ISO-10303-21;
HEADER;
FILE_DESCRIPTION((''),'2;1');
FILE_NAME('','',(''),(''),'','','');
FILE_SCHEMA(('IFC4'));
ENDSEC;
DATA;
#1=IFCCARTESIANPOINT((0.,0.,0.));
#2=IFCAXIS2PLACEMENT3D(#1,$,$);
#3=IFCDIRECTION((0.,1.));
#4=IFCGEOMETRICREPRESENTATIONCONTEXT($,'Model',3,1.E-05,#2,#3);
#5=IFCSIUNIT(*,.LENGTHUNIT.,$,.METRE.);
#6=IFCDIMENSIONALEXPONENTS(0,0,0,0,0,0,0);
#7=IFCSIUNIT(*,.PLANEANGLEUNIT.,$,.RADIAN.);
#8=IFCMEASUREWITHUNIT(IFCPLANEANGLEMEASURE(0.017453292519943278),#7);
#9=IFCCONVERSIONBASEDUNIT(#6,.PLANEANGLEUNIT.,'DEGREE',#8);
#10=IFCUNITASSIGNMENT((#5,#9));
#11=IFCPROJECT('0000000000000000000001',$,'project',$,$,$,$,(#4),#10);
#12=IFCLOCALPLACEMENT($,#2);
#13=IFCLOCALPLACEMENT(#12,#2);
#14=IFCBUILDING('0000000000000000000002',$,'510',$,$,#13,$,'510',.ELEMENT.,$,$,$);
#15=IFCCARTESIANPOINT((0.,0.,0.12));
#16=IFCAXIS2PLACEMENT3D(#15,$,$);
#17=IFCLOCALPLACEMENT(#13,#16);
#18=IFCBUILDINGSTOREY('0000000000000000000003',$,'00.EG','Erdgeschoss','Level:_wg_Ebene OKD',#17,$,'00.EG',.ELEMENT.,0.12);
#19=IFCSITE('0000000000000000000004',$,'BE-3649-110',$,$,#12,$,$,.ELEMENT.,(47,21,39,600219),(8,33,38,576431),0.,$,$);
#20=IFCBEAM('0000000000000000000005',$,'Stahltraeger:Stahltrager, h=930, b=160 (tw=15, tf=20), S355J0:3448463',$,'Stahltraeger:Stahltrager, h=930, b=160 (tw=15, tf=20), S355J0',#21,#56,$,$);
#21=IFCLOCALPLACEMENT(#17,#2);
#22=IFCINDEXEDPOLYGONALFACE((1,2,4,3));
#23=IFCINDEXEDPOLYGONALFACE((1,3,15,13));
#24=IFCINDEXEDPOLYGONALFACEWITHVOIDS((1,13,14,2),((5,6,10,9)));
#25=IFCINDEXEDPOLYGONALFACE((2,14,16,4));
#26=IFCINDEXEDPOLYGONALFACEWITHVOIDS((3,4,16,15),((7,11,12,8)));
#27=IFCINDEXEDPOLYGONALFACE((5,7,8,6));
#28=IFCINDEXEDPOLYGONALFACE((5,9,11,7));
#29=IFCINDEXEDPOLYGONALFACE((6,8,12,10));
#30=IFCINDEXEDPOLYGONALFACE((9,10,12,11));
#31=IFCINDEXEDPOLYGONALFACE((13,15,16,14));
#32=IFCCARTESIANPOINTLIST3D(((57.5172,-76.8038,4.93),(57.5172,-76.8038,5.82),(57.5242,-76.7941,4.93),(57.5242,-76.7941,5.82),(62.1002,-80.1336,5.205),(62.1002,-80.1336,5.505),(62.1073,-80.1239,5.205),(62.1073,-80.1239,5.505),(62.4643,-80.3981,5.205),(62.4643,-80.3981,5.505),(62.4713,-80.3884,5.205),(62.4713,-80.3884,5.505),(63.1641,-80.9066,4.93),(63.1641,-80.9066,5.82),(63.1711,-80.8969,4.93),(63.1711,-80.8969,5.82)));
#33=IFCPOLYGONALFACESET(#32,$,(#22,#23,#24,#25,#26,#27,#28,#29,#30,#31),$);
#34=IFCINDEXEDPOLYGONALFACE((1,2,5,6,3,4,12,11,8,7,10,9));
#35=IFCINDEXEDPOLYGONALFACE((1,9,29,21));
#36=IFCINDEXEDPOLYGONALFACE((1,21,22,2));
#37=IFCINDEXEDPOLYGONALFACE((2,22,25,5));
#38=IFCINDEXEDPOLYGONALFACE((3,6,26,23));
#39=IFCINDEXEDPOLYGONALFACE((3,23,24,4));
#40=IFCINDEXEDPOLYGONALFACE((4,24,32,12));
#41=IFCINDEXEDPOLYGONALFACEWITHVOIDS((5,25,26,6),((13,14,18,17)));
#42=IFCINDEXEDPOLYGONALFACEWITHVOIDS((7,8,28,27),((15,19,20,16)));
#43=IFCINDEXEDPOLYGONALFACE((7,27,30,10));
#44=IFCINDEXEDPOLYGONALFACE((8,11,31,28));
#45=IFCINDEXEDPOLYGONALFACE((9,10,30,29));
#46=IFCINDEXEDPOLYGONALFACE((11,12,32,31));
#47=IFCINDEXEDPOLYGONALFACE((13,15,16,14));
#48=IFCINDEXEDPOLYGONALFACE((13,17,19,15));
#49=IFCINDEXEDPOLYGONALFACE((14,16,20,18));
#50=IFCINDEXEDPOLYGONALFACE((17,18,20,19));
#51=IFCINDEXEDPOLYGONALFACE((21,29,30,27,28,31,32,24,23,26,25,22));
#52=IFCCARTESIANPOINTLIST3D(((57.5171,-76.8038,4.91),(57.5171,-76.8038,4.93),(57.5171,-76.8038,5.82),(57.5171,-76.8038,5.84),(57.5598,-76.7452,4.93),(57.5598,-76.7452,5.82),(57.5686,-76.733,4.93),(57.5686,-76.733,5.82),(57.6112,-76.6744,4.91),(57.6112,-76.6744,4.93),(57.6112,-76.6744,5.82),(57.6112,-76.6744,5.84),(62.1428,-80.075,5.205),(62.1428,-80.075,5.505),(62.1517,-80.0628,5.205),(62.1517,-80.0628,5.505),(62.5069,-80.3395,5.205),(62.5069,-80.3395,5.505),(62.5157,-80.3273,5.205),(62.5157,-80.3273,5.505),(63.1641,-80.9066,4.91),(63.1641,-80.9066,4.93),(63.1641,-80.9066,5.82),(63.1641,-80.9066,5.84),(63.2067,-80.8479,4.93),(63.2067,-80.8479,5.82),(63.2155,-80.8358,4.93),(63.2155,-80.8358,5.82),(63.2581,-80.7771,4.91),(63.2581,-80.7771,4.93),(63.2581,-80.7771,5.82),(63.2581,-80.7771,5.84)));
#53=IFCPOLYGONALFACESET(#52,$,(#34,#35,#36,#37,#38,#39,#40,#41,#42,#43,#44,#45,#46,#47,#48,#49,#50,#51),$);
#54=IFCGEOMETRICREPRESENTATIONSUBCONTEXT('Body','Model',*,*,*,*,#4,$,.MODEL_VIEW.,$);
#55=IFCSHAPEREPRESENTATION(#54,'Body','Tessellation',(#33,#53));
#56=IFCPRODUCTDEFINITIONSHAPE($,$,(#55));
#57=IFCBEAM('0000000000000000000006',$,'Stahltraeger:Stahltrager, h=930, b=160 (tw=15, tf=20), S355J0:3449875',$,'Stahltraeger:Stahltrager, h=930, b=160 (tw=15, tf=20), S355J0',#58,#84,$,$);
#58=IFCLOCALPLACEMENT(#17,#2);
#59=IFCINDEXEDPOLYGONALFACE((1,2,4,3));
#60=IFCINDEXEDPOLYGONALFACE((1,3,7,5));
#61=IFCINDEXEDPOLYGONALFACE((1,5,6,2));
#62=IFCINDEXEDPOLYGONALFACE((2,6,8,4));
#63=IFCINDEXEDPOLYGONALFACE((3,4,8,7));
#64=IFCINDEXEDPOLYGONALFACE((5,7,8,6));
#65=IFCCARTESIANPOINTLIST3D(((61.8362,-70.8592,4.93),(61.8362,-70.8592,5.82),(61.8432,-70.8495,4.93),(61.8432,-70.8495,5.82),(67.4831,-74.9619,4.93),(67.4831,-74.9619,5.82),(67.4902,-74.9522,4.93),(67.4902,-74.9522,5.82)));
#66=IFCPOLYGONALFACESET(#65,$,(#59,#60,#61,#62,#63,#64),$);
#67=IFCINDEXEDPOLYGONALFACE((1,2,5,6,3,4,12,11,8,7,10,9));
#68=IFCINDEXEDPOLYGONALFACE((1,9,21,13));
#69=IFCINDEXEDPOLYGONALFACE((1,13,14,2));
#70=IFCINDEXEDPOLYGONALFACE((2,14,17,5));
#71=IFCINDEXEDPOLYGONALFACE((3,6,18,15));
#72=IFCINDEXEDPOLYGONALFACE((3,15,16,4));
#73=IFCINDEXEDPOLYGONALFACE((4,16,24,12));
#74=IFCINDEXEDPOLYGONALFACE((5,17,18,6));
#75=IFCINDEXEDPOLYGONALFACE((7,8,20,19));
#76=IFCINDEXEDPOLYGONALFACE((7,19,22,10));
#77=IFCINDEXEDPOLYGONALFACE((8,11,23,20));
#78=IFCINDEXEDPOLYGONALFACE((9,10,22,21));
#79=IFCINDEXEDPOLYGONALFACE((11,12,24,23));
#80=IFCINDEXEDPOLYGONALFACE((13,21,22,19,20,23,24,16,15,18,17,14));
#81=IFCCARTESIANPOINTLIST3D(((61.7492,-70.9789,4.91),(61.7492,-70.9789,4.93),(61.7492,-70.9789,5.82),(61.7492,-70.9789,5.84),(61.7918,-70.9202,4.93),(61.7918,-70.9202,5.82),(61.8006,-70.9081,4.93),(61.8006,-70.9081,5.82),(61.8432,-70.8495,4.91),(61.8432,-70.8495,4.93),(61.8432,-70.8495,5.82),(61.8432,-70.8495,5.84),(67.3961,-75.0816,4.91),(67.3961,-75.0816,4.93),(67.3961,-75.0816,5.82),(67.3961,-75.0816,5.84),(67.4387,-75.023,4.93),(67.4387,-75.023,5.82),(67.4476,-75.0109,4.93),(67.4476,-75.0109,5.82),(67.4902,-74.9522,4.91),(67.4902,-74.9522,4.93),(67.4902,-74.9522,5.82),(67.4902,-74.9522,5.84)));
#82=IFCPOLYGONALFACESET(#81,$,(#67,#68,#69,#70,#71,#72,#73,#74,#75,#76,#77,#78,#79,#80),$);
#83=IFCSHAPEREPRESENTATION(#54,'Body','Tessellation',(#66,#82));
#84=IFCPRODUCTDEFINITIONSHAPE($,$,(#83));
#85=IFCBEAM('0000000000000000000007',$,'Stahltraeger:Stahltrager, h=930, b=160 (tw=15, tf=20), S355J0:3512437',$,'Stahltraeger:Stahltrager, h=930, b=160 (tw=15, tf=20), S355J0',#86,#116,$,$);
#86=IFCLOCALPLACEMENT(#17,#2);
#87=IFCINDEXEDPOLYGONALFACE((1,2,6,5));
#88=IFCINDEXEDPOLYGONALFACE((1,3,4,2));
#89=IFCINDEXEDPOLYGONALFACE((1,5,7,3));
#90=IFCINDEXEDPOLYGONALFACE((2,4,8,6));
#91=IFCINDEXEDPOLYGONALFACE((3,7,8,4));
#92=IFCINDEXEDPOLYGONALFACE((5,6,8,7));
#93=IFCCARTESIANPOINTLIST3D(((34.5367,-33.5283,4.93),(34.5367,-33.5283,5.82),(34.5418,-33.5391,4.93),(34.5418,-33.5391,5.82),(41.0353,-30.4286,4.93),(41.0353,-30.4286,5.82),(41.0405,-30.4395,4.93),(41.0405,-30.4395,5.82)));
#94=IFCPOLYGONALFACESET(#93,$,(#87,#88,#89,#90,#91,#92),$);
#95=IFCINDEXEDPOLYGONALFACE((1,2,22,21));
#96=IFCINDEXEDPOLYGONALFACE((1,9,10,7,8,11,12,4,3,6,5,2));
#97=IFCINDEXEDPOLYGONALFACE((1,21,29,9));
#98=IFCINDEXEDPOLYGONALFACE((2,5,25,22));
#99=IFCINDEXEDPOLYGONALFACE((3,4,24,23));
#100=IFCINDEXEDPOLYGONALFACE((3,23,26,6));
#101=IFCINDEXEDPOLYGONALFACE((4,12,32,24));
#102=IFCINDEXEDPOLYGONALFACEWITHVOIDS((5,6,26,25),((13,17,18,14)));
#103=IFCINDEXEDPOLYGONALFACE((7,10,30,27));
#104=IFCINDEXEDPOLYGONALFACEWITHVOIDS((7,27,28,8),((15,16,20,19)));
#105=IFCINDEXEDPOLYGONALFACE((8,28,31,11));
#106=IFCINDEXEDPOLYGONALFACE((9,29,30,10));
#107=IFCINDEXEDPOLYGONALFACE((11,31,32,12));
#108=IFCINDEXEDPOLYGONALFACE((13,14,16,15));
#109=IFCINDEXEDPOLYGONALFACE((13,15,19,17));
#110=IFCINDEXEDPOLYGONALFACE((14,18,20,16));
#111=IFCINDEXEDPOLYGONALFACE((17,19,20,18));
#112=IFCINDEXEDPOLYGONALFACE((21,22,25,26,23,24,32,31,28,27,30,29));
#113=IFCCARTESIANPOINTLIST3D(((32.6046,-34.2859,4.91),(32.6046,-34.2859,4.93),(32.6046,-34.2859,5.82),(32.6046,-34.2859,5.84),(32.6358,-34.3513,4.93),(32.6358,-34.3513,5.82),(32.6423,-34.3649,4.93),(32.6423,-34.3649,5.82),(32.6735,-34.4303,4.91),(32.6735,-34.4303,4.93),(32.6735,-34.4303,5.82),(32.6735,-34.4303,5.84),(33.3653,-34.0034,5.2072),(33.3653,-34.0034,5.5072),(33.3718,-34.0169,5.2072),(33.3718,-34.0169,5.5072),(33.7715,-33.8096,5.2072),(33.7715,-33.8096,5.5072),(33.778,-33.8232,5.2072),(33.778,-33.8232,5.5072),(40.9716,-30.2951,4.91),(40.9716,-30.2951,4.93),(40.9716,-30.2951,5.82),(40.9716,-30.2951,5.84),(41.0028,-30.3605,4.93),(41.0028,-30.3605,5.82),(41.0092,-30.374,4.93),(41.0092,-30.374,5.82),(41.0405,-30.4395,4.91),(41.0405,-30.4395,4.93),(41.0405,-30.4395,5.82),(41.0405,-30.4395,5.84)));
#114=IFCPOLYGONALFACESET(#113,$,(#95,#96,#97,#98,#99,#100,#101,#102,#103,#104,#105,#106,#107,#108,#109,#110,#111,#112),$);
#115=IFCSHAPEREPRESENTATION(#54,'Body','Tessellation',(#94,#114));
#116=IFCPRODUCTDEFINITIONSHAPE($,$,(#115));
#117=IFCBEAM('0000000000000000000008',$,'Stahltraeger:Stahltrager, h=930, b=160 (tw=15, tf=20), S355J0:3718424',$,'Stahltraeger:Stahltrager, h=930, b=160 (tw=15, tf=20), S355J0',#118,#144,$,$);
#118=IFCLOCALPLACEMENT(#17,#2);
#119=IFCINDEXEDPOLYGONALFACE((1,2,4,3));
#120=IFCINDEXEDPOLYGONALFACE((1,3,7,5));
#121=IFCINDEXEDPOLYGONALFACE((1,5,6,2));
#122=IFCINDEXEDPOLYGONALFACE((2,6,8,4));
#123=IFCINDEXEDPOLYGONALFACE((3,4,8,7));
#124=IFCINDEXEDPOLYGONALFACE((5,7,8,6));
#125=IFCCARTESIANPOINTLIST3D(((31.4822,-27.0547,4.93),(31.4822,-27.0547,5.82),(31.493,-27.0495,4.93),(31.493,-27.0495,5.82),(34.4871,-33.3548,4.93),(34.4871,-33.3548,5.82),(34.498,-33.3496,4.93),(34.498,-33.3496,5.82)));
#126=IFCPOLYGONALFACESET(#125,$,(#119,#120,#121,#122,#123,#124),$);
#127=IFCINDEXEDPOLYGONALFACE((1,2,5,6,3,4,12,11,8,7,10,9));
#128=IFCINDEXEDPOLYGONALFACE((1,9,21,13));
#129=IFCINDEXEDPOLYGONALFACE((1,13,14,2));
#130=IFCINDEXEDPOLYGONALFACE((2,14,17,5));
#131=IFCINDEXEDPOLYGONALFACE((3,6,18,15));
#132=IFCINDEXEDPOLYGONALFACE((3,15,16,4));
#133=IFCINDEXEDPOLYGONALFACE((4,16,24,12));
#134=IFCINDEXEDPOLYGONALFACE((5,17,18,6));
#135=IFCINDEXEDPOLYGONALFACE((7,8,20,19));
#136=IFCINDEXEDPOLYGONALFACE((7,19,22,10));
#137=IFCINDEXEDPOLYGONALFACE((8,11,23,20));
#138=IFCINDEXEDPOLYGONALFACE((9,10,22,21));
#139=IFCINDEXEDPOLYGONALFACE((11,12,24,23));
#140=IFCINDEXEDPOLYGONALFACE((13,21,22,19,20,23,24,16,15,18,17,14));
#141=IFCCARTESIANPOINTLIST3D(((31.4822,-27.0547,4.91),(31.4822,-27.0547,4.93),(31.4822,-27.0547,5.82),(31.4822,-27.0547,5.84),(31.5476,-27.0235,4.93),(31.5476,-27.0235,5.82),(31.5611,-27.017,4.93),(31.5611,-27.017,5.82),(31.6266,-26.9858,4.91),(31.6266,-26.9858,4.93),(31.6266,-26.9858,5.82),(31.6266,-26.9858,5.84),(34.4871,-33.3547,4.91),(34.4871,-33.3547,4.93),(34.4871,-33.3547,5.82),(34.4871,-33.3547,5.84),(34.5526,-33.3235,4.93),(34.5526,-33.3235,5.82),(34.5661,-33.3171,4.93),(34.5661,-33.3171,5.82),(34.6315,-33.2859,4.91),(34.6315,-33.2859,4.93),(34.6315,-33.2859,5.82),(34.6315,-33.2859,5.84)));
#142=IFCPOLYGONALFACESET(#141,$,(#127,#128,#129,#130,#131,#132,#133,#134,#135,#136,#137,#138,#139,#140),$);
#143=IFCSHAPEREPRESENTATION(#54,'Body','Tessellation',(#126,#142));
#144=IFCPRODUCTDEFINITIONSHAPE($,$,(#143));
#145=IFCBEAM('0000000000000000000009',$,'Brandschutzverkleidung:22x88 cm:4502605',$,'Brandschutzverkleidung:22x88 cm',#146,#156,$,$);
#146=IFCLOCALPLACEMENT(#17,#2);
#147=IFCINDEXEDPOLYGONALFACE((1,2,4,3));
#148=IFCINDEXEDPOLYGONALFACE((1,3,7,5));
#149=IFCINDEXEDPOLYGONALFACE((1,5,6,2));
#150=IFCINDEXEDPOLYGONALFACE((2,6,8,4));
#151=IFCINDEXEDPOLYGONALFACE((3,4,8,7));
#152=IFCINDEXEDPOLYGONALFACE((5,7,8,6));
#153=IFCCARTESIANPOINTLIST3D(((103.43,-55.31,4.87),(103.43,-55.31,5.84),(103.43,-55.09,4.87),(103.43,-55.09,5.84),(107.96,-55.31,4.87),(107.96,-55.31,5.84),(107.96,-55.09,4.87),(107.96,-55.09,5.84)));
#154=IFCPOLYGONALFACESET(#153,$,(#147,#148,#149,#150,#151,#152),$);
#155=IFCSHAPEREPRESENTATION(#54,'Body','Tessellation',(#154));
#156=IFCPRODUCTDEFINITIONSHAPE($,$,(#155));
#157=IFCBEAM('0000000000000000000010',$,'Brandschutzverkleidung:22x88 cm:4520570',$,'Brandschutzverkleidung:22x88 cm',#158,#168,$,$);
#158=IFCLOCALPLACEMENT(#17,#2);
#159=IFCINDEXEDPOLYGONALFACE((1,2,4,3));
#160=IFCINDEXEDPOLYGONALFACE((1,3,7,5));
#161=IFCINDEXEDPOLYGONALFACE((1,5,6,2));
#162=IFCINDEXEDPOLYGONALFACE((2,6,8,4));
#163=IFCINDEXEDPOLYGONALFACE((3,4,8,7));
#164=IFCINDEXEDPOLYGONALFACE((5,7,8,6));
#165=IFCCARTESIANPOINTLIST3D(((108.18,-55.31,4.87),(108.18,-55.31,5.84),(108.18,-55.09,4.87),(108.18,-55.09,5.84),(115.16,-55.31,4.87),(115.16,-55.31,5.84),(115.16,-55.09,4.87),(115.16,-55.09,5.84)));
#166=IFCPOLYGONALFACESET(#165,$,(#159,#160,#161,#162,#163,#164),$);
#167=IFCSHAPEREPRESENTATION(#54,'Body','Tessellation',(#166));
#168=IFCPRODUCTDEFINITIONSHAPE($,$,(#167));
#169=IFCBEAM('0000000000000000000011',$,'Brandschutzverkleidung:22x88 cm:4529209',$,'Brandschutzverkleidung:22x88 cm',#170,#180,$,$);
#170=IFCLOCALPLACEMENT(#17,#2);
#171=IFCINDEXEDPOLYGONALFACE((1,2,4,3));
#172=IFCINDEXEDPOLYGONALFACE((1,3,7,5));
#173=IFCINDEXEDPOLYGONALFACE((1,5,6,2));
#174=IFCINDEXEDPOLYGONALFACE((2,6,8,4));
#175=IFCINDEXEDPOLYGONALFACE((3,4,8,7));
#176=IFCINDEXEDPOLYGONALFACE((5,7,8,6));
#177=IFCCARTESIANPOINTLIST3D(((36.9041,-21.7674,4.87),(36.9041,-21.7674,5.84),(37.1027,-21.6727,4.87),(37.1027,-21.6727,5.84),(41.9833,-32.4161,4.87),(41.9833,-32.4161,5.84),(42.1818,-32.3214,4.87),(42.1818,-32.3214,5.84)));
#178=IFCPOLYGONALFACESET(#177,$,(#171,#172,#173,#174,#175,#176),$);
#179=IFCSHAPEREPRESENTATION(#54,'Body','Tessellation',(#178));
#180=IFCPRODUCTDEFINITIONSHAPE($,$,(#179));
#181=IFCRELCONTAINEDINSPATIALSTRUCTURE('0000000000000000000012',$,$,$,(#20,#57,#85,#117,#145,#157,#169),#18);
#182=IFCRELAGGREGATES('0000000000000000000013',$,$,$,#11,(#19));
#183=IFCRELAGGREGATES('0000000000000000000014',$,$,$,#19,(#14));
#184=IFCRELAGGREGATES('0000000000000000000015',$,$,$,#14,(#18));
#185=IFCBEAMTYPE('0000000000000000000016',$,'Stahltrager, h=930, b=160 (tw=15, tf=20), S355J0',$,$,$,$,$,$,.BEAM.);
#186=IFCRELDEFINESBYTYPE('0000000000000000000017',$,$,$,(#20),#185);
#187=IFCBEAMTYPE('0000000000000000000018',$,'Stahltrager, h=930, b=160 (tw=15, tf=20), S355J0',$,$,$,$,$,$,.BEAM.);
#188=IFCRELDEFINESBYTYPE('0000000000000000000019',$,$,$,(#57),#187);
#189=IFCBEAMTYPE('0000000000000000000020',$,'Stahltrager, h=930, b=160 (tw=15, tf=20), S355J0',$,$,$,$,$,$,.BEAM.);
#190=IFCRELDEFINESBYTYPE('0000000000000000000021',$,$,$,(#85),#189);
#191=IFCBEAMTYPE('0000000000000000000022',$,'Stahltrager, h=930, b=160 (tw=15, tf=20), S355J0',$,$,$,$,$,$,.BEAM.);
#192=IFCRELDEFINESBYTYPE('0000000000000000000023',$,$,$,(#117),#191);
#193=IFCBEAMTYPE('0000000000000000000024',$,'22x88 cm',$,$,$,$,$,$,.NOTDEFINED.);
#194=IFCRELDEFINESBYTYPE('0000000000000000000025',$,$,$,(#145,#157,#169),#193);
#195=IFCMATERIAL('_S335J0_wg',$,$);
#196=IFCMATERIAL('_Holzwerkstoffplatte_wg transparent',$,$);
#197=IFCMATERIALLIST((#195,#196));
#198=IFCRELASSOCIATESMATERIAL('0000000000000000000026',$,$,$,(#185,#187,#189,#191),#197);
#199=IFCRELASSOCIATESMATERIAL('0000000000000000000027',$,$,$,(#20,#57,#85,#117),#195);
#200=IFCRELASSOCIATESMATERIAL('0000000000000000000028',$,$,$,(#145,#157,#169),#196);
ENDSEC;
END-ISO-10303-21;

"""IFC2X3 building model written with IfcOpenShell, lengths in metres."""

from ifc_helpers import new_model, entity, si_unit, converted_unit, direction, frame, frame_2d, origin, origin_2d_with_axis, place, context, subcontext, project, spatial, polyline, rectangle, i_section, outline, extrude, boolean, source, transform, mapped, material, material_list, type_object, type_shapes, element, save


model = new_model("IFC2X3")

# Units and contexts
model_context = context("Model", 3, precision=1e-05, world=origin(), true_north=direction((0.0, 1.0)))
body_context = subcontext(model_context, "Body", "Model", "MODEL_VIEW")
ifc_project = project(units=[si_unit("LENGTHUNIT", "METRE"), converted_unit("PLANEANGLEUNIT", "DEGREE", entity("IfcPlaneAngleMeasure", 0.017453292519943278), si_unit("PLANEANGLEUNIT", "RADIAN"), dimensions=[0, 0, 0, 0, 0, 0, 0])], contexts=[model_context])

# Site, building, storey
site_placement = place(None, origin())
site = spatial("IfcSite", under=ifc_project, at=site_placement, Name="BE-3649-110", CompositionType="ELEMENT", RefLatitude=(47, 21, 39, 600219), RefLongitude=(8, 33, 38, 576431), RefElevation=0.0)
building_placement = place(site_placement, origin())
building = spatial("IfcBuilding", under=site, at=building_placement, Name="510", LongName="510", CompositionType="ELEMENT")
storey_placement = place(building_placement, frame((0.0, 0.0, 0.12)))
storey = spatial("IfcBuildingStorey", under=building, at=storey_placement, Name="00.EG", Description="Erdgeschoss", ObjectType="Level:_wg_Ebene OKD", LongName="00.EG", CompositionType="ELEMENT", Elevation=0.12)

# Beams
ifc_material_1 = material(Name="_S335J0_wg")
ifc_material_2 = material(Name="_Holzwerkstoffplatte_wg transparent")
ifc_material_list = material_list([ifc_material_1, ifc_material_2])
beam_type_1 = type_object("IfcBeamType", Name="Stahltrager, h=930, b=160 (tw=15, tf=20), S355J0", PredefinedType="BEAM", material=ifc_material_list)
shared_shape_1 = source(origin(), body_context, "Body", "SweptSolid", [
    boolean("DIFFERENCE", extrude(rectangle(XDim=0.89, YDim=0.012, at=frame_2d((0.0, 0.0), x_axis=(0.0, 1.0))), frame((57.5207, -76.799, 5.495), z_axis=(0.809017, -0.587785, 0.0), x_axis=(0.587785, 0.809017, 0.0)), (0.0, 0.0, 1.0), 6.98), extrude(rectangle(XDim=0.3, YDim=0.45, at=frame_2d((0.0, 0.0), x_axis=(0.0, 1.0))), frame((62.2823, -80.2659, 5.475), z_axis=(0.587785, 0.809017, 0.0), x_axis=(0.809017, -0.587785, 0.0)), (0.0, 0.0, 1.0), 0.012)),
    boolean("DIFFERENCE", extrude(i_section(OverallWidth=0.16, OverallDepth=0.93, WebThickness=0.015, FlangeThickness=0.02, at=frame_2d((0.0, 0.0), x_axis=(0.0, 1.0))), frame((57.5642, -76.7391, 5.495), z_axis=(0.809017, -0.587785, 0.0), x_axis=(0.0, 0.0, -1.0)), (0.0, 0.0, 1.0), 6.98), extrude(rectangle(XDim=0.3, YDim=0.45, at=frame_2d((0.0, 0.0), x_axis=(0.0, 1.0))), frame((62.3249, -80.2072, 5.475), z_axis=(0.587785, 0.809017, 0.0), x_axis=(0.809017, -0.587785, 0.0)), (0.0, 0.0, 1.0), 0.015)),
])
type_shapes(beam_type_1, [shared_shape_1])
beam_1_placement = place(storey_placement, frame((0.0, 0.0, -0.12)))
element("IfcBeam", 1, at=beam_1_placement, inside=storey, type_object=beam_type_1, material=ifc_material_1, Name="Stahltraeger:Stahltrager, h=930, b=160 (tw=15, tf=20), S355J0:3448463", ObjectType="Stahltraeger:Stahltrager, h=930, b=160 (tw=15, tf=20), S355J0", context=body_context, shape_type="MappedRepresentation", body=[
    mapped(shared_shape_1, transform((0.0, 0.0, 0.0), scale=1.0)),
])
beam_type_2 = type_object("IfcBeamType", Name="Stahltrager, h=930, b=160 (tw=15, tf=20), S355J0", PredefinedType="BEAM", material=ifc_material_list)
shared_shape_2 = source(origin(), body_context, "Body", "SweptSolid", [
    extrude(rectangle(XDim=0.89, YDim=0.012, at=origin_2d_with_axis()), frame((61.8397, -70.8543, 5.495), z_axis=(0.809017, -0.587785, 0.0), x_axis=(0.0, 0.0, -1.0)), (0.0, 0.0, 1.0), 6.98),
    extrude(i_section(OverallWidth=0.16, OverallDepth=0.93, WebThickness=0.015, FlangeThickness=0.02, at=frame_2d((0.0, 0.0), x_axis=(0.0, 1.0))), frame((61.7962, -70.9142, 5.495), z_axis=(0.809017, -0.587785, 0.0), x_axis=(0.0, 0.0, -1.0)), (0.0, 0.0, 1.0), 6.98),
])
type_shapes(beam_type_2, [shared_shape_2])
beam_2_placement = place(storey_placement, frame((0.0, 0.0, -0.12)))
element("IfcBeam", 2, at=beam_2_placement, inside=storey, type_object=beam_type_2, material=ifc_material_1, Name="Stahltraeger:Stahltrager, h=930, b=160 (tw=15, tf=20), S355J0:3449875", ObjectType="Stahltraeger:Stahltrager, h=930, b=160 (tw=15, tf=20), S355J0", context=body_context, shape_type="MappedRepresentation", body=[
    mapped(shared_shape_2, transform((0.0, 0.0, 0.0), scale=1.0)),
])
beam_type_3 = type_object("IfcBeamType", Name="Stahltrager, h=930, b=160 (tw=15, tf=20), S355J0", PredefinedType="BEAM", material=ifc_material_list)
shared_shape_3 = source(origin(), body_context, "Body", "SweptSolid", [
    extrude(rectangle(XDim=0.89, YDim=0.012, at=origin_2d_with_axis()), frame((34.5393, -33.5337, 5.495), z_axis=(0.902585, 0.430511, 0.0), x_axis=(0.0, 0.0, 1.0)), (0.0, 0.0, 1.0), 7.2),
    boolean("DIFFERENCE", extrude(outline(polyline([(0.445, -0.08), (0.465, -0.08), (0.465, 0.08), (0.445, 0.08), (0.445, 0.0075), (-0.445, 0.0075), (-0.445, 0.08), (-0.465, 0.08), (-0.465, -0.08), (-0.445, -0.08), (-0.445, -0.0075), (0.445, -0.0075), (0.445, -0.08)])), frame((32.639, -34.3581, 5.495), z_axis=(0.902585, 0.430511, 0.0), x_axis=(0.0, 0.0, 1.0)), (0.0, 0.0, 1.0), 9.27), extrude(rectangle(XDim=0.3, YDim=0.45, at=frame_2d((0.0, 0.0), x_axis=(0.0, 1.0))), frame((33.5749, -33.92, 5.4772), z_axis=(-0.430511, 0.902585, 0.0), x_axis=(0.902585, 0.430511, 0.0)), (0.0, 0.0, 1.0), 0.015)),
])
type_shapes(beam_type_3, [shared_shape_3])
beam_3_placement = place(storey_placement, frame((0.0, 0.0, -0.12)))
element("IfcBeam", 3, at=beam_3_placement, inside=storey, type_object=beam_type_3, material=ifc_material_1, Name="Stahltraeger:Stahltrager, h=930, b=160 (tw=15, tf=20), S355J0:3512437", ObjectType="Stahltraeger:Stahltrager, h=930, b=160 (tw=15, tf=20), S355J0", context=body_context, shape_type="MappedRepresentation", body=[
    mapped(shared_shape_3, transform((0.0, 0.0, 0.0), scale=1.0)),
])
beam_type_4 = type_object("IfcBeamType", Name="Stahltrager, h=930, b=160 (tw=15, tf=20), S355J0", PredefinedType="BEAM", material=ifc_material_list)
shared_shape_4 = source(origin(), body_context, "Body", "SweptSolid", [
    extrude(rectangle(XDim=0.89, YDim=0.012, at=origin_2d_with_axis()), frame((31.4876, -27.0521, 5.495), z_axis=(0.430511, -0.902585, 0.0), x_axis=(0.0, 0.0, -1.0)), (0.0, 0.0, 1.0), 6.98),
    extrude(i_section(OverallWidth=0.16, OverallDepth=0.93, WebThickness=0.015, FlangeThickness=0.02, at=frame_2d((0.0, 0.0), x_axis=(0.0, 1.0))), frame((31.5544, -27.0203, 5.495), z_axis=(0.430511, -0.902585, 0.0), x_axis=(0.0, 0.0, -1.0)), (0.0, 0.0, 1.0), 6.98),
])
type_shapes(beam_type_4, [shared_shape_4])
beam_4_placement = place(storey_placement, frame((0.0, 0.0, -0.12)))
element("IfcBeam", 4, at=beam_4_placement, inside=storey, type_object=beam_type_4, material=ifc_material_1, Name="Stahltraeger:Stahltrager, h=930, b=160 (tw=15, tf=20), S355J0:3718424", ObjectType="Stahltraeger:Stahltrager, h=930, b=160 (tw=15, tf=20), S355J0", context=body_context, shape_type="MappedRepresentation", body=[
    mapped(shared_shape_4, transform((0.0, 0.0, 0.0), scale=1.0)),
])
beam_type_5 = type_object("IfcBeamType", Name="22x88 cm", PredefinedType="NOTDEFINED")
beam_5_placement = place(storey_placement, frame((0.0, 0.0, 5.355)))
element("IfcBeam", 5, at=beam_5_placement, inside=storey, type_object=beam_type_5, material=ifc_material_2, Name="Brandschutzverkleidung:22x88 cm:4502605", ObjectType="Brandschutzverkleidung:22x88 cm", context=body_context, shape_type="SweptSolid", body=[
    extrude(rectangle(XDim=0.97, YDim=0.22, at=origin_2d_with_axis()), frame((103.43, -55.2, 0.0), z_axis=(1.0, 0.0, 0.0), x_axis=(0.0, 0.0, -1.0)), (0.0, 0.0, 1.0), 4.53),
])
beam_6_placement = place(storey_placement, frame((0.0, 0.0, 5.355)))
element("IfcBeam", 6, at=beam_6_placement, inside=storey, type_object=beam_type_5, material=ifc_material_2, Name="Brandschutzverkleidung:22x88 cm:4520570", ObjectType="Brandschutzverkleidung:22x88 cm", context=body_context, shape_type="SweptSolid", body=[
    extrude(rectangle(XDim=0.97, YDim=0.22, at=origin_2d_with_axis()), frame((108.18, -55.2, 0.0), z_axis=(1.0, 0.0, 0.0), x_axis=(0.0, 0.0, -1.0)), (0.0, 0.0, 1.0), 6.98),
])
beam_7_placement = place(storey_placement, frame((0.0, 0.0, 5.355)))
element("IfcBeam", 7, at=beam_7_placement, inside=storey, type_object=beam_type_5, material=ifc_material_2, Name="Brandschutzverkleidung:22x88 cm:4529209", ObjectType="Brandschutzverkleidung:22x88 cm", context=body_context, shape_type="SweptSolid", body=[
    extrude(rectangle(XDim=0.97, YDim=0.22, at=frame_2d((0.0, 0.0), x_axis=(0.0, 1.0))), frame((42.0825, -32.3687, 0.0), z_axis=(-0.430511, 0.902585, 0.0), x_axis=(0.902585, 0.430511, 0.0)), (0.0, 0.0, 1.0), 11.798),
])

save(model, "model.ifc")
